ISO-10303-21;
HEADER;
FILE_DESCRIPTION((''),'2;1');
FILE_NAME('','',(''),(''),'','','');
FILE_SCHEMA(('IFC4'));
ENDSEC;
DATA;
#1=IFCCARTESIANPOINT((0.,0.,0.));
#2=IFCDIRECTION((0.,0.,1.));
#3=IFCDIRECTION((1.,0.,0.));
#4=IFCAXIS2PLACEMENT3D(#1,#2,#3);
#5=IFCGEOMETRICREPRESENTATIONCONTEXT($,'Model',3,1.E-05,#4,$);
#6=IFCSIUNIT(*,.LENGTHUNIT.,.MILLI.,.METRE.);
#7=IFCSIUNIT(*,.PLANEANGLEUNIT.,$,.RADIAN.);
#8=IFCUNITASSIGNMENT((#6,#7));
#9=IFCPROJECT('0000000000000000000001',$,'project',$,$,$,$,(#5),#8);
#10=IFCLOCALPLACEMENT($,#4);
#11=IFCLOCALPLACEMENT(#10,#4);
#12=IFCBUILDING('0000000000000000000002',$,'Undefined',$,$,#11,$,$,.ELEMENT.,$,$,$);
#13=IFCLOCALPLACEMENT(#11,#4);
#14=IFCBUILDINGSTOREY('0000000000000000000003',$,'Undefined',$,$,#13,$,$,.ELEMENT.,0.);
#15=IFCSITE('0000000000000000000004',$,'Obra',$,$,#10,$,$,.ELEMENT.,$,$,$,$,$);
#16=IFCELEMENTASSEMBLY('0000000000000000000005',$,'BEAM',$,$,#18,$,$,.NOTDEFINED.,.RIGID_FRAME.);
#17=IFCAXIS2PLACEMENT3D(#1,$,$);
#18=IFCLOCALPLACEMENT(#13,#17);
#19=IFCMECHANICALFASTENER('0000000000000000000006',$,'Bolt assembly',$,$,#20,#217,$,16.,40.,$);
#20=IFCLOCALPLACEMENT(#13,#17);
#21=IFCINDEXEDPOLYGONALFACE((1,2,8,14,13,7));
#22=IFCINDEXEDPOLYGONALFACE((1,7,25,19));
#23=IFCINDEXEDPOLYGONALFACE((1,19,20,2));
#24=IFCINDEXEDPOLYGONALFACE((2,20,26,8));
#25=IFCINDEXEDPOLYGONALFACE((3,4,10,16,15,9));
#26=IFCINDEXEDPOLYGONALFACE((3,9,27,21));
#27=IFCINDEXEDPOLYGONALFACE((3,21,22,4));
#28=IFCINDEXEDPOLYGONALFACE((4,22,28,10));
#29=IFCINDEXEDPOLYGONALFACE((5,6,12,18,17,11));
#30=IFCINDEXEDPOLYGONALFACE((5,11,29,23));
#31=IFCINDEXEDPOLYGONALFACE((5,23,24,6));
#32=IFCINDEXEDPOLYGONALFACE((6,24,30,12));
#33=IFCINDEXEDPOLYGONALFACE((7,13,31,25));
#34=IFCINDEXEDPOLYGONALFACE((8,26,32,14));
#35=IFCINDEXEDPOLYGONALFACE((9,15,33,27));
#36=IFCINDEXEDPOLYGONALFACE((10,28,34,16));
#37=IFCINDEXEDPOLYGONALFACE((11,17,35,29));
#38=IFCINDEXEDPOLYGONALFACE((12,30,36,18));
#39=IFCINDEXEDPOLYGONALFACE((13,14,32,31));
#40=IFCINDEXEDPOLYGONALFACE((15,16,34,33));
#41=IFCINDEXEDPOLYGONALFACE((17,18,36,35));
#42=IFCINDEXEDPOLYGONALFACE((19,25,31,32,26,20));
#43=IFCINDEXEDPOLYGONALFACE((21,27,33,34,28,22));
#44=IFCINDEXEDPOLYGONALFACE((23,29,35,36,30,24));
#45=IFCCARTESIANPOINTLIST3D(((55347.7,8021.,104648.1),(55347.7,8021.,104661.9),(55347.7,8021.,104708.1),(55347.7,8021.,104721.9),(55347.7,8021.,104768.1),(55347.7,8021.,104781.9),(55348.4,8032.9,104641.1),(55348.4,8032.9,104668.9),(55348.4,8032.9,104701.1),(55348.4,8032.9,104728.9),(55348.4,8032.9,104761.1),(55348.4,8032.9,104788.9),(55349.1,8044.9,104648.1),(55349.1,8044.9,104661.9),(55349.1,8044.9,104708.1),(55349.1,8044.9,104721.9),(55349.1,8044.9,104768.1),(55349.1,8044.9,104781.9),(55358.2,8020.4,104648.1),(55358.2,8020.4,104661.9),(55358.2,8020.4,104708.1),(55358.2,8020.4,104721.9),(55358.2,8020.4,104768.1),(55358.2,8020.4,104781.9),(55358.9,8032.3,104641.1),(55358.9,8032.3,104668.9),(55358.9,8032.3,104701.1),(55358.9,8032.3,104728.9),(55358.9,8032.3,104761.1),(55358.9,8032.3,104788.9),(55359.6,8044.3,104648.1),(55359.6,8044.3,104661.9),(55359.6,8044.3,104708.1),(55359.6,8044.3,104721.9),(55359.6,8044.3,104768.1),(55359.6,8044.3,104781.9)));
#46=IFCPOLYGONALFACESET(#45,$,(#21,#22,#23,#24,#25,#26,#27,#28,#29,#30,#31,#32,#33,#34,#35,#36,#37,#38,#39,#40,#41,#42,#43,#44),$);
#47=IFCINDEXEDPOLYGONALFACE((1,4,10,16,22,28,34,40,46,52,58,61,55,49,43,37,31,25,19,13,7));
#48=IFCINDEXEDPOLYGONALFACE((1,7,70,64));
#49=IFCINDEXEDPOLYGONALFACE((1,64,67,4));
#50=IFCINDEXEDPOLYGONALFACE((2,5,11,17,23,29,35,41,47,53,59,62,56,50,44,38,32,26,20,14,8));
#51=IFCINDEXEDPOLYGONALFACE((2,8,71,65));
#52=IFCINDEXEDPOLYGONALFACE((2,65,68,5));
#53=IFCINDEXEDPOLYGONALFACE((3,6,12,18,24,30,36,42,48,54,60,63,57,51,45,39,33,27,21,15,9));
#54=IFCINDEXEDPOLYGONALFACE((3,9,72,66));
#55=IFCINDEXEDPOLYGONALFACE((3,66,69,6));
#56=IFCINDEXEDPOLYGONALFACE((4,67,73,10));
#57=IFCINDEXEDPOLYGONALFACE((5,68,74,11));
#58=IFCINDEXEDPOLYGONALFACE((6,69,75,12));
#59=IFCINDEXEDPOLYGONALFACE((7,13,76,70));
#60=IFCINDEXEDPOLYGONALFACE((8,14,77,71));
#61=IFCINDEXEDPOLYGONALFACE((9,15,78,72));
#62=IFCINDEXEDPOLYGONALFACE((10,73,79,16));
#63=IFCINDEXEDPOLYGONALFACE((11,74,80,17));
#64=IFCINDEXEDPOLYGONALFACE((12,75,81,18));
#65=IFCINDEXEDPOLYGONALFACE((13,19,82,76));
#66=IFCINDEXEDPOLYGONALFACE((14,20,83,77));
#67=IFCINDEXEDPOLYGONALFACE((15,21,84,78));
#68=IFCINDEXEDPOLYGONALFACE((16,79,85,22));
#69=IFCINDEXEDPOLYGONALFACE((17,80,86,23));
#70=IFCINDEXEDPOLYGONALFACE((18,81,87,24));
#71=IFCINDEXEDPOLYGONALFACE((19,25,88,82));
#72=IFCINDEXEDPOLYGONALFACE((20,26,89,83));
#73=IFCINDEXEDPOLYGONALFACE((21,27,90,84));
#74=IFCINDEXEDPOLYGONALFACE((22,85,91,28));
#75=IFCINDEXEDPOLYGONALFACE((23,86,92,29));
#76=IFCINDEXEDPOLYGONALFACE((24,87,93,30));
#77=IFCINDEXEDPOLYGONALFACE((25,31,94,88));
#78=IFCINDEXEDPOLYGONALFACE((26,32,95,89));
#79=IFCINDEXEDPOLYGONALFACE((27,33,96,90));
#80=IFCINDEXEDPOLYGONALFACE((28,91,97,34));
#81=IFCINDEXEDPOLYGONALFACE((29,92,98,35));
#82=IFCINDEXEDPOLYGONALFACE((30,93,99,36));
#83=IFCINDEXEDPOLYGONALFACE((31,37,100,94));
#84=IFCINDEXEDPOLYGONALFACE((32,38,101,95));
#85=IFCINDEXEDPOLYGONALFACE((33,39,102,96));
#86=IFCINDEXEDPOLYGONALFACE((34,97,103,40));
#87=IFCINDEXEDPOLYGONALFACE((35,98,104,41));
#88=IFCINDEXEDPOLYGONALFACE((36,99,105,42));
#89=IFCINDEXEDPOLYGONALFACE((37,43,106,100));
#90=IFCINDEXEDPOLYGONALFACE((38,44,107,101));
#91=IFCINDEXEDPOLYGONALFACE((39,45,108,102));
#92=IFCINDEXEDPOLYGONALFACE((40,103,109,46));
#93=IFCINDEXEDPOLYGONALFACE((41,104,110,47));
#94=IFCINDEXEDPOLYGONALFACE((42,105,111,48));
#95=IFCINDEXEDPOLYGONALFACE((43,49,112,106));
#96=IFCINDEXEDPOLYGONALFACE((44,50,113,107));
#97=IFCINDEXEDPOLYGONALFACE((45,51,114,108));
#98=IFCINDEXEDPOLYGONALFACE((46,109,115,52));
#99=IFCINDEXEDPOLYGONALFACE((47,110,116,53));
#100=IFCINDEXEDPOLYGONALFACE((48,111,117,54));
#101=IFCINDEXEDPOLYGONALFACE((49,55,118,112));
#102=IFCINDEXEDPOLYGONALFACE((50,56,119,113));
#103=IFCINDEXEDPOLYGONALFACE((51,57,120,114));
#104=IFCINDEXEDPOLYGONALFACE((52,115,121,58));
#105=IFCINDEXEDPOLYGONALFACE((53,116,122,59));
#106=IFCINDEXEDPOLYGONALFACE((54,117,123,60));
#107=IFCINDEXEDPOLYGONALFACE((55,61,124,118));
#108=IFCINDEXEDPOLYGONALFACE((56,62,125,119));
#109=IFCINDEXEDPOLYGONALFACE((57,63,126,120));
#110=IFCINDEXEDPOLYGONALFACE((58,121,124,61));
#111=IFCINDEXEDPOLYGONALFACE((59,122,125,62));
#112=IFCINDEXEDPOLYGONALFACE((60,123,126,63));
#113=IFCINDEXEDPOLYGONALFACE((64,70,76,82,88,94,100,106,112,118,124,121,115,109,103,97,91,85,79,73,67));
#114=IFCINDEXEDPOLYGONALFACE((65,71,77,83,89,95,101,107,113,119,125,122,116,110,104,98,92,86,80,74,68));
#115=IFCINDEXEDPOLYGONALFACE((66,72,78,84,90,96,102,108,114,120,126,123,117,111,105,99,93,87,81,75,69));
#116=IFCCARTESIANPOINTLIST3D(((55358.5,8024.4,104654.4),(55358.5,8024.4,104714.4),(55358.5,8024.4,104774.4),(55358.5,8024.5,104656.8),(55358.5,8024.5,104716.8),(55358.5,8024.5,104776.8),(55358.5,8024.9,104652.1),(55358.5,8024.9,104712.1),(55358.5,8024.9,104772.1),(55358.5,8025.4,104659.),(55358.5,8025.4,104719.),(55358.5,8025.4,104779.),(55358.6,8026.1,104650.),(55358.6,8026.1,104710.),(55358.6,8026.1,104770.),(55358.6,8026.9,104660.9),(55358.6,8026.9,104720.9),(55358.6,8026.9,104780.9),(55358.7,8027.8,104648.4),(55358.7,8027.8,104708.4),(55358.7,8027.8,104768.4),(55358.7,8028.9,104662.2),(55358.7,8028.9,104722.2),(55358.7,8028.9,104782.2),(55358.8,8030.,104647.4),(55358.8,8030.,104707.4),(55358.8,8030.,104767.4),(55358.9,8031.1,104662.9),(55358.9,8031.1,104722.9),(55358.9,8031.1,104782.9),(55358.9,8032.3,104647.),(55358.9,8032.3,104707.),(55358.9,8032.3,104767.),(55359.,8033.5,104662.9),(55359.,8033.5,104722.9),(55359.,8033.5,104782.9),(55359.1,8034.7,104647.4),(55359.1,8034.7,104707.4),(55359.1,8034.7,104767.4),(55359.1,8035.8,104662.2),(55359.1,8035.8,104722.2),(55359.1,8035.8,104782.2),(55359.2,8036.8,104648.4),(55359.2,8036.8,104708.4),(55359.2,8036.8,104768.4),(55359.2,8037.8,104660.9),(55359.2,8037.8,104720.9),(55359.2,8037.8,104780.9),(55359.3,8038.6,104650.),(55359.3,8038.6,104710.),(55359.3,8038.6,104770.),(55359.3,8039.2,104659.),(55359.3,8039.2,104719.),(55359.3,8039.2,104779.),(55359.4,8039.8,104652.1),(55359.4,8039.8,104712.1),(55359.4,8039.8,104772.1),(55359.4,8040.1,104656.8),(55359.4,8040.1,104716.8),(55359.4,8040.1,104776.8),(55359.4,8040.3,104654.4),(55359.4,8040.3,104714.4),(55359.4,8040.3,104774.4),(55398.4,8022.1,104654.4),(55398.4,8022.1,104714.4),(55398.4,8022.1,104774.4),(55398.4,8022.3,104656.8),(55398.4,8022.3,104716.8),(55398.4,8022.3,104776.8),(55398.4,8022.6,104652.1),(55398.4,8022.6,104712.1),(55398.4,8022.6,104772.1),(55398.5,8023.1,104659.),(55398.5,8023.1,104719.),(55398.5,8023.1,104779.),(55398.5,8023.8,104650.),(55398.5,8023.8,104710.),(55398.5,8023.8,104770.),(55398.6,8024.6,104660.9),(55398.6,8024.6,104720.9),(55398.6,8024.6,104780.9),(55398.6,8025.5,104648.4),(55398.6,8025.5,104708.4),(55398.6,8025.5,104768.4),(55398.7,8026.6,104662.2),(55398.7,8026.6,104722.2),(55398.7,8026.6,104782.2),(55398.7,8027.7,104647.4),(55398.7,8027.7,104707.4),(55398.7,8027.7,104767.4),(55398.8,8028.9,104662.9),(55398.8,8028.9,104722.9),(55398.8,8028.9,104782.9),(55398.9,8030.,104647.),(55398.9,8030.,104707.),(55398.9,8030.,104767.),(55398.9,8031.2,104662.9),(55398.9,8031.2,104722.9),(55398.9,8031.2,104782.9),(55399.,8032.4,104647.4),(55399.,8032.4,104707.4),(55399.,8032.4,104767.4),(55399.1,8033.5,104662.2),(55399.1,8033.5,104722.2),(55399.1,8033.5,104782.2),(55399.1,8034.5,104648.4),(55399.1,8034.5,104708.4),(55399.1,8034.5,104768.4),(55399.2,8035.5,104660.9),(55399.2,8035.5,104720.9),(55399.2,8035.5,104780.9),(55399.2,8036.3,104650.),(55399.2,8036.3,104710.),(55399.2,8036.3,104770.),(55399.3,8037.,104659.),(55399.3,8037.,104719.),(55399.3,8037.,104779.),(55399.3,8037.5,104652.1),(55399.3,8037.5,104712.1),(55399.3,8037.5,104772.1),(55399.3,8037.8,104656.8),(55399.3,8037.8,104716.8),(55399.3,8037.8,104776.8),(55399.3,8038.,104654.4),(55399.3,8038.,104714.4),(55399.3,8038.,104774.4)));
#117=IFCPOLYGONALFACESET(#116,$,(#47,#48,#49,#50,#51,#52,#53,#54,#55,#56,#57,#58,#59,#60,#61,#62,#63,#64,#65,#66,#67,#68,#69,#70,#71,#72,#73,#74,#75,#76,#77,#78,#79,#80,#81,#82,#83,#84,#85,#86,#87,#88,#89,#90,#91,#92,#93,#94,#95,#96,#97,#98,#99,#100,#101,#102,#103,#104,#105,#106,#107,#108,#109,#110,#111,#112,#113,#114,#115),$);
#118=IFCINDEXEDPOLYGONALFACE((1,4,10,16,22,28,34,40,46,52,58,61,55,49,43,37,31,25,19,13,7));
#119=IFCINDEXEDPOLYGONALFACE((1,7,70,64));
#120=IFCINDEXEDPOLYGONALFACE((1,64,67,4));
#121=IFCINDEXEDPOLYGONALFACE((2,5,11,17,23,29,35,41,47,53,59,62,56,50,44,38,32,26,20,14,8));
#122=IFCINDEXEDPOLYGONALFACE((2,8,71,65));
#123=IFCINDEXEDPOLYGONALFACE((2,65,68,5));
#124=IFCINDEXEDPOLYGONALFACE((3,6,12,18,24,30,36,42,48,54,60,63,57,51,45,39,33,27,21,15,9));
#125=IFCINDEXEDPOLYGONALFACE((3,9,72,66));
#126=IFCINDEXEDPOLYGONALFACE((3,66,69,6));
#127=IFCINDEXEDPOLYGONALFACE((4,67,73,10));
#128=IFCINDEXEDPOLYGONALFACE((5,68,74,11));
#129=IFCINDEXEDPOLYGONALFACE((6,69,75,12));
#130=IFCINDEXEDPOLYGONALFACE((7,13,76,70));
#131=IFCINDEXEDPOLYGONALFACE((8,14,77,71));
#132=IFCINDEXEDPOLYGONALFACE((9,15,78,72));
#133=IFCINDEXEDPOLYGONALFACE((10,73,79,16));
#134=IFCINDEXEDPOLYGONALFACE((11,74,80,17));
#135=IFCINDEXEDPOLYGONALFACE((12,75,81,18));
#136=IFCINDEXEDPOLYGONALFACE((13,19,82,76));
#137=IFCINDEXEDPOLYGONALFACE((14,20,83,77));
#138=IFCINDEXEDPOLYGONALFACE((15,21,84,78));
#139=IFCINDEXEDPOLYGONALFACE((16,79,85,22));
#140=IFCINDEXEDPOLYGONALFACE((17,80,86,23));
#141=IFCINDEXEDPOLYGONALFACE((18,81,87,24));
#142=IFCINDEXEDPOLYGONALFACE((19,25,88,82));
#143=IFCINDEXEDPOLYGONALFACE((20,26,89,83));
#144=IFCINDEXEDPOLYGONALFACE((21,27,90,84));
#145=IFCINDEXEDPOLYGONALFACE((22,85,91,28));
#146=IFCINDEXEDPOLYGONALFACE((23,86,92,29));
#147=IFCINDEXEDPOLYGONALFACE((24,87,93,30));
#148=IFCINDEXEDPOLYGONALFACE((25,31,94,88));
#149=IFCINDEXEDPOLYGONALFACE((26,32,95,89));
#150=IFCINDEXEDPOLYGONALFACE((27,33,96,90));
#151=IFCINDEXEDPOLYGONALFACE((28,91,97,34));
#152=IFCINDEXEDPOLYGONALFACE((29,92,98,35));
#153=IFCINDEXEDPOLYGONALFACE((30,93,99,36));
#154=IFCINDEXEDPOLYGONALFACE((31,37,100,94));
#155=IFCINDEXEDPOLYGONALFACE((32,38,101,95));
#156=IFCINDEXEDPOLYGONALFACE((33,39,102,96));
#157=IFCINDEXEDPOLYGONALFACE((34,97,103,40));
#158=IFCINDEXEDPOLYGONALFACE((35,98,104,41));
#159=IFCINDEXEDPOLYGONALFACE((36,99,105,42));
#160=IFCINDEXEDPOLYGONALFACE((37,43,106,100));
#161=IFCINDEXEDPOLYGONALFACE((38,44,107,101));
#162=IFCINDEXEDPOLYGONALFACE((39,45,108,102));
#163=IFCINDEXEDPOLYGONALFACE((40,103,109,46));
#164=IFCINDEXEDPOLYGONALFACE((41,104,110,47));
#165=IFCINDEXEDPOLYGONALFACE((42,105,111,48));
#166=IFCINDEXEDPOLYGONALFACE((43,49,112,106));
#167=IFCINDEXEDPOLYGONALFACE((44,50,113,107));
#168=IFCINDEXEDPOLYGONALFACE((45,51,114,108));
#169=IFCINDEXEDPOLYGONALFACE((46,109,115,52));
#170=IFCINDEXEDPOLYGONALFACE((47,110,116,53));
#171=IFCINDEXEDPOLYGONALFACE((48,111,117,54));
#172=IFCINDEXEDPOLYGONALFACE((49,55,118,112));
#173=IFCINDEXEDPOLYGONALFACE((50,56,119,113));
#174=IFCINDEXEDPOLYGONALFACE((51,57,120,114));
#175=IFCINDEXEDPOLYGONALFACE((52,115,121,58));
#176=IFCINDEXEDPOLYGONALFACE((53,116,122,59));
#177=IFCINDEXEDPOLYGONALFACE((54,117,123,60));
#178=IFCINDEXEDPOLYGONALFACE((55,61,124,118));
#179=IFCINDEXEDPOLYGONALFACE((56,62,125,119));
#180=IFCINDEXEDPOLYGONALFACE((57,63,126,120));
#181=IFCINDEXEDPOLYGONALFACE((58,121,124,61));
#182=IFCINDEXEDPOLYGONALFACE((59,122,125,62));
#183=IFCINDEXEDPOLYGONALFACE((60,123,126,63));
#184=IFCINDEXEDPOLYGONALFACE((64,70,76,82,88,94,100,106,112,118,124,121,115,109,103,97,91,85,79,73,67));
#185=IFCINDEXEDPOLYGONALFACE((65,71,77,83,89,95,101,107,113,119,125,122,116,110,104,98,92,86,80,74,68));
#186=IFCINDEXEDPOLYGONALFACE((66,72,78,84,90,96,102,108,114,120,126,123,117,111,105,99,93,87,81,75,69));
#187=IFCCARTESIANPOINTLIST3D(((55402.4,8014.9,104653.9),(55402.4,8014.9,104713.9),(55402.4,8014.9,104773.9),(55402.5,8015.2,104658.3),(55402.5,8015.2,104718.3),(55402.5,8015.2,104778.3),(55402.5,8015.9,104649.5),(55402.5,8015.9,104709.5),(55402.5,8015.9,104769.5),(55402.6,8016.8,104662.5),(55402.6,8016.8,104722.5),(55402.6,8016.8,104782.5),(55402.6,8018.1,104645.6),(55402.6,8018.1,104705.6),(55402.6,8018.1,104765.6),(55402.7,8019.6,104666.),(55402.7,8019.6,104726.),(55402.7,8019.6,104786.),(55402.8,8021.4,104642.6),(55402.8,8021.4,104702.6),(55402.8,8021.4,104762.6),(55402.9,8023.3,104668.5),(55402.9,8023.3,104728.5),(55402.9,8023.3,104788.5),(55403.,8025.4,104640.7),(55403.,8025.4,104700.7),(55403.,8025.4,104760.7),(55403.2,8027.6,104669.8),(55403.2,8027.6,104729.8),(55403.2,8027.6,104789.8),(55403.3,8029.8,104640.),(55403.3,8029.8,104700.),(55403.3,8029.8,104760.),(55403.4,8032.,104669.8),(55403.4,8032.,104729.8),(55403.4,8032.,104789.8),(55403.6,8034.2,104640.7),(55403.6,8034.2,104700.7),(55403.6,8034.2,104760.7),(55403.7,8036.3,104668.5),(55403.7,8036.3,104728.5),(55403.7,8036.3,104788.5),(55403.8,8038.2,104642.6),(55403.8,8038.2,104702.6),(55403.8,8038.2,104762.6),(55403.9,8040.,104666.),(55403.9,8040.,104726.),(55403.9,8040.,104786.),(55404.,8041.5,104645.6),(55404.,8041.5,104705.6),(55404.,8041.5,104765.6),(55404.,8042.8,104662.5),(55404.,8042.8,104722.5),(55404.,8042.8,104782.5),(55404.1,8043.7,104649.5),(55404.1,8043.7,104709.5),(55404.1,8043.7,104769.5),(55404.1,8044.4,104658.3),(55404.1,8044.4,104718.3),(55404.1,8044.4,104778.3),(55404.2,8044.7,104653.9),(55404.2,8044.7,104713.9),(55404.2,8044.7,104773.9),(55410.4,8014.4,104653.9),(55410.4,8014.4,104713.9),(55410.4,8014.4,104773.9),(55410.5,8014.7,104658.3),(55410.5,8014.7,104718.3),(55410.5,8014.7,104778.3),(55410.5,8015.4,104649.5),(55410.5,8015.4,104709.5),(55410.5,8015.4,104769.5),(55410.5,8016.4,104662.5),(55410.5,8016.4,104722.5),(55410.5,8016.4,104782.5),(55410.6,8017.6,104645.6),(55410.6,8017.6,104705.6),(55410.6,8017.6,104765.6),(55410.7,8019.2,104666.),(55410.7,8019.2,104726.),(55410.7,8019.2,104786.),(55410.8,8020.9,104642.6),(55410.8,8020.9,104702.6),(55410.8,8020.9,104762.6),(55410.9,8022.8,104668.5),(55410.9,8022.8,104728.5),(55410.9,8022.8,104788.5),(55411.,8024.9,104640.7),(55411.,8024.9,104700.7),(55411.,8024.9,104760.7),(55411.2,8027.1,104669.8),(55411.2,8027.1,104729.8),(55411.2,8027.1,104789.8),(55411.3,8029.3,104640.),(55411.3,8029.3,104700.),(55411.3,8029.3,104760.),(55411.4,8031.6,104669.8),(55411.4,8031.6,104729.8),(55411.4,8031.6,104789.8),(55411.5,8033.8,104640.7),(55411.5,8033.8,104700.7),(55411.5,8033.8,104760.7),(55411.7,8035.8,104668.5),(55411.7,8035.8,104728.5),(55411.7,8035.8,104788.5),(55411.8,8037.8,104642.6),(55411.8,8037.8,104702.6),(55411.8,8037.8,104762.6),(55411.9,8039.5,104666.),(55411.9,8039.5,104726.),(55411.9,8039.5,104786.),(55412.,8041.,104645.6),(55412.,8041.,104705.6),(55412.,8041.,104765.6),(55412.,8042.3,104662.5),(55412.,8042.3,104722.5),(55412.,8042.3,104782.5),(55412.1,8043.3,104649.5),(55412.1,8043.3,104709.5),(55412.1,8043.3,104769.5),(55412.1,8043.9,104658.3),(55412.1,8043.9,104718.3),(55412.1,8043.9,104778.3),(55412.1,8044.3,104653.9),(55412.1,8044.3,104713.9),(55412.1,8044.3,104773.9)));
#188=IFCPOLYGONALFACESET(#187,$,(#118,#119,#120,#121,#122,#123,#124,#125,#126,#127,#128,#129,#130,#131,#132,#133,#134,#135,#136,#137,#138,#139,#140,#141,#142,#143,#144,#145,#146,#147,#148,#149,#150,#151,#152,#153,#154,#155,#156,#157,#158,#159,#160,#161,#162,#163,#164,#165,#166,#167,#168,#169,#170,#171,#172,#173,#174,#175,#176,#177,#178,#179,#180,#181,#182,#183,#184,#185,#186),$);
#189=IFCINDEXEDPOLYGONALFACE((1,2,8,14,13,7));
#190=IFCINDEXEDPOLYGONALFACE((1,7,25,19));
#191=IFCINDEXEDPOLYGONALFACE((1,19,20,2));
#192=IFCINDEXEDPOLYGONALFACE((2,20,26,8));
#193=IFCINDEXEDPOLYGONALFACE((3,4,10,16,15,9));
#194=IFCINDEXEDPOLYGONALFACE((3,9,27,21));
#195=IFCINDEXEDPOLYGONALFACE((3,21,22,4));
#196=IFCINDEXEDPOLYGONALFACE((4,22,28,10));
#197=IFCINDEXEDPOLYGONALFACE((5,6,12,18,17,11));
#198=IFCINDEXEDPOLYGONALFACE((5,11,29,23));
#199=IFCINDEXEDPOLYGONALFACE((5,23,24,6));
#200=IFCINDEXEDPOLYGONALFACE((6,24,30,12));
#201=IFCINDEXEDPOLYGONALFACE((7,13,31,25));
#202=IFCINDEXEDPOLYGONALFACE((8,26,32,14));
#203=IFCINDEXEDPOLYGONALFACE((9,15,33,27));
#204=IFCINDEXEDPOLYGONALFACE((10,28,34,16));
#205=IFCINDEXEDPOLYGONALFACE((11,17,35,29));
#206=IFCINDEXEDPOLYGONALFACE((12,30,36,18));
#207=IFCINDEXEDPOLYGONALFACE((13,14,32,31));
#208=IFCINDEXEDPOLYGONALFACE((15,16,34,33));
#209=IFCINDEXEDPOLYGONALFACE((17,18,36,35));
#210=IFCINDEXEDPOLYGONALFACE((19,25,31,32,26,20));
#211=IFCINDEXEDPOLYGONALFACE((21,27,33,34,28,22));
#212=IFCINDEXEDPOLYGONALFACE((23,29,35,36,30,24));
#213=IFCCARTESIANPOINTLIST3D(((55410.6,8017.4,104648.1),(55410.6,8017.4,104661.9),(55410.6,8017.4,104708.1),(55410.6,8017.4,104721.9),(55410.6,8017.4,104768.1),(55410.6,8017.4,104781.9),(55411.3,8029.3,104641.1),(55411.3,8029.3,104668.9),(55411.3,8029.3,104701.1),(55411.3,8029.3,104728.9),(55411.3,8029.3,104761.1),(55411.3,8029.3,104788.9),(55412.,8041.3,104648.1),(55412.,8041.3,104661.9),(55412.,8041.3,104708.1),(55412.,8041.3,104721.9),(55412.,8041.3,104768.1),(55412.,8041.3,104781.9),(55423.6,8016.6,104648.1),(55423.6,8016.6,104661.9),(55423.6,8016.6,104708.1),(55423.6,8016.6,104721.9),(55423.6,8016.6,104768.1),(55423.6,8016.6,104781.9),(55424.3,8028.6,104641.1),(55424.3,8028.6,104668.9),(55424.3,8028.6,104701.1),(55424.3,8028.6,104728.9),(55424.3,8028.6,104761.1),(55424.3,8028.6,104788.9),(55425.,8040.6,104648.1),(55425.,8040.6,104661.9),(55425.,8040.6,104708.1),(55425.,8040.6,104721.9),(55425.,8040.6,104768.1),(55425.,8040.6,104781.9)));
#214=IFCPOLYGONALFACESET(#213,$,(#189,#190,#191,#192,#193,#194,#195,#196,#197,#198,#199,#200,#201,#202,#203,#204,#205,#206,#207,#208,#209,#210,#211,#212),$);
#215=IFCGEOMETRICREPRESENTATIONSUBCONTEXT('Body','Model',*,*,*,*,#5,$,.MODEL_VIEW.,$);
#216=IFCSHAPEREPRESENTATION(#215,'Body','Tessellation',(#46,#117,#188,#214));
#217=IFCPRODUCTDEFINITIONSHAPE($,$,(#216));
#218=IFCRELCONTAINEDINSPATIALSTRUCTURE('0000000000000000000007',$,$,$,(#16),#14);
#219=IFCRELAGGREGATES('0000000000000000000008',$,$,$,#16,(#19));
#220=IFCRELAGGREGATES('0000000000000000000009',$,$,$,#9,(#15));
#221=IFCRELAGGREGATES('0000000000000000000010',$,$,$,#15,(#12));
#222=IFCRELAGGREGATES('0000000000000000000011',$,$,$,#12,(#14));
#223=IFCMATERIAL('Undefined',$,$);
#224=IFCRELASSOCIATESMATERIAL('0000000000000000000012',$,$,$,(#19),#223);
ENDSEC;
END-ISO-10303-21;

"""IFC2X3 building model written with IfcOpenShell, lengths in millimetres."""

from ifc_helpers import new_model, si_unit, frame, origin_with_axes, origin_2d_with_axis, place, context, subcontext, project, spatial, polyline, circle, outline, extrude, source, transform, mapped, material, element, aggregate, save


model = new_model("IFC2X3")

# Units and contexts
model_context = context("Model", 3, precision=1e-05, world=origin_with_axes())
body_context = subcontext(model_context, "Body", "Model", "MODEL_VIEW")
ifc_project = project(units=[si_unit("LENGTHUNIT", "METRE", prefix="MILLI"), si_unit("PLANEANGLEUNIT", "RADIAN")], contexts=[model_context])

# Site, building, storey
site_placement = place(None, origin_with_axes())
site = spatial("IfcSite", under=ifc_project, at=site_placement, Name="Obra", CompositionType="ELEMENT")
building_placement = place(site_placement, origin_with_axes())
building = spatial("IfcBuilding", under=site, at=building_placement, Name="Undefined", CompositionType="ELEMENT")
storey_placement = place(building_placement, origin_with_axes())
storey = spatial("IfcBuildingStorey", under=building, at=storey_placement, Name="Undefined", CompositionType="ELEMENT", Elevation=0.0)

# Element assembly
ifc_material_1 = material(Name="Undefined")
assembly_1_placement = place(storey_placement, origin_with_axes())
assembly_1 = element("IfcElementAssembly", 1, at=assembly_1_placement, inside=storey, Name="BEAM", AssemblyPlace="NOTDEFINED", PredefinedType="RIGID_FRAME")

# Shared definitions
shared_shape_1 = source(origin_with_axes(), body_context, "Body", "SweptSolid", [
    extrude(outline(polyline([(13.9, 0.0), (6.9, 12.0), (-6.9, 12.0), (-13.9, 0.0), (-6.9, -12.0), (6.9, -12.0), (13.9, 0.0)])), frame((0.0, -19.7, 0.0), z_axis=(0.0, 1.0, 0.0), x_axis=(1.0, 0.0, 0.0)), (0.0, 0.0, 1.0), 10.6),
    extrude(circle(Radius=8.0, at=origin_2d_with_axis()), frame((0.0, -9.1, 0.0), z_axis=(0.0, 1.0, 0.0), x_axis=(1.0, 0.0, 0.0)), (0.0, 0.0, 1.0), 40.0),
    extrude(circle(Radius=15.0, at=origin_2d_with_axis()), frame((0.0, 35.3, 0.0), z_axis=(0.0, 1.0, 0.0), x_axis=(1.0, 0.0, 0.0)), (0.0, 0.0, 1.0), 8.0),
    extrude(outline(polyline([(13.9, 0.0), (6.9, 12.0), (-6.9, 12.0), (-13.9, 0.0), (-6.9, -12.0), (6.9, -12.0), (13.9, 0.0)])), frame((0.0, 43.3, 0.0), z_axis=(0.0, 1.0, 0.0), x_axis=(1.0, 0.0, 0.0)), (0.0, 0.0, 1.0), 13.0),
])

# Mechanical fastener
mechanical_fastener_1_placement = place(assembly_1_placement, frame((55370.9, 8081.7, 104835.0), z_axis=(-0.05711, -0.998368, 0.0), x_axis=(0.0, 0.0, -1.0)))
mechanical_fastener_1 = element("IfcMechanicalFastener", 2, at=mechanical_fastener_1_placement, material=ifc_material_1, Name="Bolt assembly", NominalDiameter=16.0, NominalLength=40.0, context=body_context, shape_type="MappedRepresentation", body=[
    mapped(shared_shape_1, transform((60.0, 0.0, 50.0))),
    mapped(shared_shape_1, transform((120.0, 0.0, 50.0))),
    mapped(shared_shape_1, transform((180.0, 0.0, 50.0))),
])
aggregate(assembly_1, [mechanical_fastener_1])

save(model, "model.ifc")
